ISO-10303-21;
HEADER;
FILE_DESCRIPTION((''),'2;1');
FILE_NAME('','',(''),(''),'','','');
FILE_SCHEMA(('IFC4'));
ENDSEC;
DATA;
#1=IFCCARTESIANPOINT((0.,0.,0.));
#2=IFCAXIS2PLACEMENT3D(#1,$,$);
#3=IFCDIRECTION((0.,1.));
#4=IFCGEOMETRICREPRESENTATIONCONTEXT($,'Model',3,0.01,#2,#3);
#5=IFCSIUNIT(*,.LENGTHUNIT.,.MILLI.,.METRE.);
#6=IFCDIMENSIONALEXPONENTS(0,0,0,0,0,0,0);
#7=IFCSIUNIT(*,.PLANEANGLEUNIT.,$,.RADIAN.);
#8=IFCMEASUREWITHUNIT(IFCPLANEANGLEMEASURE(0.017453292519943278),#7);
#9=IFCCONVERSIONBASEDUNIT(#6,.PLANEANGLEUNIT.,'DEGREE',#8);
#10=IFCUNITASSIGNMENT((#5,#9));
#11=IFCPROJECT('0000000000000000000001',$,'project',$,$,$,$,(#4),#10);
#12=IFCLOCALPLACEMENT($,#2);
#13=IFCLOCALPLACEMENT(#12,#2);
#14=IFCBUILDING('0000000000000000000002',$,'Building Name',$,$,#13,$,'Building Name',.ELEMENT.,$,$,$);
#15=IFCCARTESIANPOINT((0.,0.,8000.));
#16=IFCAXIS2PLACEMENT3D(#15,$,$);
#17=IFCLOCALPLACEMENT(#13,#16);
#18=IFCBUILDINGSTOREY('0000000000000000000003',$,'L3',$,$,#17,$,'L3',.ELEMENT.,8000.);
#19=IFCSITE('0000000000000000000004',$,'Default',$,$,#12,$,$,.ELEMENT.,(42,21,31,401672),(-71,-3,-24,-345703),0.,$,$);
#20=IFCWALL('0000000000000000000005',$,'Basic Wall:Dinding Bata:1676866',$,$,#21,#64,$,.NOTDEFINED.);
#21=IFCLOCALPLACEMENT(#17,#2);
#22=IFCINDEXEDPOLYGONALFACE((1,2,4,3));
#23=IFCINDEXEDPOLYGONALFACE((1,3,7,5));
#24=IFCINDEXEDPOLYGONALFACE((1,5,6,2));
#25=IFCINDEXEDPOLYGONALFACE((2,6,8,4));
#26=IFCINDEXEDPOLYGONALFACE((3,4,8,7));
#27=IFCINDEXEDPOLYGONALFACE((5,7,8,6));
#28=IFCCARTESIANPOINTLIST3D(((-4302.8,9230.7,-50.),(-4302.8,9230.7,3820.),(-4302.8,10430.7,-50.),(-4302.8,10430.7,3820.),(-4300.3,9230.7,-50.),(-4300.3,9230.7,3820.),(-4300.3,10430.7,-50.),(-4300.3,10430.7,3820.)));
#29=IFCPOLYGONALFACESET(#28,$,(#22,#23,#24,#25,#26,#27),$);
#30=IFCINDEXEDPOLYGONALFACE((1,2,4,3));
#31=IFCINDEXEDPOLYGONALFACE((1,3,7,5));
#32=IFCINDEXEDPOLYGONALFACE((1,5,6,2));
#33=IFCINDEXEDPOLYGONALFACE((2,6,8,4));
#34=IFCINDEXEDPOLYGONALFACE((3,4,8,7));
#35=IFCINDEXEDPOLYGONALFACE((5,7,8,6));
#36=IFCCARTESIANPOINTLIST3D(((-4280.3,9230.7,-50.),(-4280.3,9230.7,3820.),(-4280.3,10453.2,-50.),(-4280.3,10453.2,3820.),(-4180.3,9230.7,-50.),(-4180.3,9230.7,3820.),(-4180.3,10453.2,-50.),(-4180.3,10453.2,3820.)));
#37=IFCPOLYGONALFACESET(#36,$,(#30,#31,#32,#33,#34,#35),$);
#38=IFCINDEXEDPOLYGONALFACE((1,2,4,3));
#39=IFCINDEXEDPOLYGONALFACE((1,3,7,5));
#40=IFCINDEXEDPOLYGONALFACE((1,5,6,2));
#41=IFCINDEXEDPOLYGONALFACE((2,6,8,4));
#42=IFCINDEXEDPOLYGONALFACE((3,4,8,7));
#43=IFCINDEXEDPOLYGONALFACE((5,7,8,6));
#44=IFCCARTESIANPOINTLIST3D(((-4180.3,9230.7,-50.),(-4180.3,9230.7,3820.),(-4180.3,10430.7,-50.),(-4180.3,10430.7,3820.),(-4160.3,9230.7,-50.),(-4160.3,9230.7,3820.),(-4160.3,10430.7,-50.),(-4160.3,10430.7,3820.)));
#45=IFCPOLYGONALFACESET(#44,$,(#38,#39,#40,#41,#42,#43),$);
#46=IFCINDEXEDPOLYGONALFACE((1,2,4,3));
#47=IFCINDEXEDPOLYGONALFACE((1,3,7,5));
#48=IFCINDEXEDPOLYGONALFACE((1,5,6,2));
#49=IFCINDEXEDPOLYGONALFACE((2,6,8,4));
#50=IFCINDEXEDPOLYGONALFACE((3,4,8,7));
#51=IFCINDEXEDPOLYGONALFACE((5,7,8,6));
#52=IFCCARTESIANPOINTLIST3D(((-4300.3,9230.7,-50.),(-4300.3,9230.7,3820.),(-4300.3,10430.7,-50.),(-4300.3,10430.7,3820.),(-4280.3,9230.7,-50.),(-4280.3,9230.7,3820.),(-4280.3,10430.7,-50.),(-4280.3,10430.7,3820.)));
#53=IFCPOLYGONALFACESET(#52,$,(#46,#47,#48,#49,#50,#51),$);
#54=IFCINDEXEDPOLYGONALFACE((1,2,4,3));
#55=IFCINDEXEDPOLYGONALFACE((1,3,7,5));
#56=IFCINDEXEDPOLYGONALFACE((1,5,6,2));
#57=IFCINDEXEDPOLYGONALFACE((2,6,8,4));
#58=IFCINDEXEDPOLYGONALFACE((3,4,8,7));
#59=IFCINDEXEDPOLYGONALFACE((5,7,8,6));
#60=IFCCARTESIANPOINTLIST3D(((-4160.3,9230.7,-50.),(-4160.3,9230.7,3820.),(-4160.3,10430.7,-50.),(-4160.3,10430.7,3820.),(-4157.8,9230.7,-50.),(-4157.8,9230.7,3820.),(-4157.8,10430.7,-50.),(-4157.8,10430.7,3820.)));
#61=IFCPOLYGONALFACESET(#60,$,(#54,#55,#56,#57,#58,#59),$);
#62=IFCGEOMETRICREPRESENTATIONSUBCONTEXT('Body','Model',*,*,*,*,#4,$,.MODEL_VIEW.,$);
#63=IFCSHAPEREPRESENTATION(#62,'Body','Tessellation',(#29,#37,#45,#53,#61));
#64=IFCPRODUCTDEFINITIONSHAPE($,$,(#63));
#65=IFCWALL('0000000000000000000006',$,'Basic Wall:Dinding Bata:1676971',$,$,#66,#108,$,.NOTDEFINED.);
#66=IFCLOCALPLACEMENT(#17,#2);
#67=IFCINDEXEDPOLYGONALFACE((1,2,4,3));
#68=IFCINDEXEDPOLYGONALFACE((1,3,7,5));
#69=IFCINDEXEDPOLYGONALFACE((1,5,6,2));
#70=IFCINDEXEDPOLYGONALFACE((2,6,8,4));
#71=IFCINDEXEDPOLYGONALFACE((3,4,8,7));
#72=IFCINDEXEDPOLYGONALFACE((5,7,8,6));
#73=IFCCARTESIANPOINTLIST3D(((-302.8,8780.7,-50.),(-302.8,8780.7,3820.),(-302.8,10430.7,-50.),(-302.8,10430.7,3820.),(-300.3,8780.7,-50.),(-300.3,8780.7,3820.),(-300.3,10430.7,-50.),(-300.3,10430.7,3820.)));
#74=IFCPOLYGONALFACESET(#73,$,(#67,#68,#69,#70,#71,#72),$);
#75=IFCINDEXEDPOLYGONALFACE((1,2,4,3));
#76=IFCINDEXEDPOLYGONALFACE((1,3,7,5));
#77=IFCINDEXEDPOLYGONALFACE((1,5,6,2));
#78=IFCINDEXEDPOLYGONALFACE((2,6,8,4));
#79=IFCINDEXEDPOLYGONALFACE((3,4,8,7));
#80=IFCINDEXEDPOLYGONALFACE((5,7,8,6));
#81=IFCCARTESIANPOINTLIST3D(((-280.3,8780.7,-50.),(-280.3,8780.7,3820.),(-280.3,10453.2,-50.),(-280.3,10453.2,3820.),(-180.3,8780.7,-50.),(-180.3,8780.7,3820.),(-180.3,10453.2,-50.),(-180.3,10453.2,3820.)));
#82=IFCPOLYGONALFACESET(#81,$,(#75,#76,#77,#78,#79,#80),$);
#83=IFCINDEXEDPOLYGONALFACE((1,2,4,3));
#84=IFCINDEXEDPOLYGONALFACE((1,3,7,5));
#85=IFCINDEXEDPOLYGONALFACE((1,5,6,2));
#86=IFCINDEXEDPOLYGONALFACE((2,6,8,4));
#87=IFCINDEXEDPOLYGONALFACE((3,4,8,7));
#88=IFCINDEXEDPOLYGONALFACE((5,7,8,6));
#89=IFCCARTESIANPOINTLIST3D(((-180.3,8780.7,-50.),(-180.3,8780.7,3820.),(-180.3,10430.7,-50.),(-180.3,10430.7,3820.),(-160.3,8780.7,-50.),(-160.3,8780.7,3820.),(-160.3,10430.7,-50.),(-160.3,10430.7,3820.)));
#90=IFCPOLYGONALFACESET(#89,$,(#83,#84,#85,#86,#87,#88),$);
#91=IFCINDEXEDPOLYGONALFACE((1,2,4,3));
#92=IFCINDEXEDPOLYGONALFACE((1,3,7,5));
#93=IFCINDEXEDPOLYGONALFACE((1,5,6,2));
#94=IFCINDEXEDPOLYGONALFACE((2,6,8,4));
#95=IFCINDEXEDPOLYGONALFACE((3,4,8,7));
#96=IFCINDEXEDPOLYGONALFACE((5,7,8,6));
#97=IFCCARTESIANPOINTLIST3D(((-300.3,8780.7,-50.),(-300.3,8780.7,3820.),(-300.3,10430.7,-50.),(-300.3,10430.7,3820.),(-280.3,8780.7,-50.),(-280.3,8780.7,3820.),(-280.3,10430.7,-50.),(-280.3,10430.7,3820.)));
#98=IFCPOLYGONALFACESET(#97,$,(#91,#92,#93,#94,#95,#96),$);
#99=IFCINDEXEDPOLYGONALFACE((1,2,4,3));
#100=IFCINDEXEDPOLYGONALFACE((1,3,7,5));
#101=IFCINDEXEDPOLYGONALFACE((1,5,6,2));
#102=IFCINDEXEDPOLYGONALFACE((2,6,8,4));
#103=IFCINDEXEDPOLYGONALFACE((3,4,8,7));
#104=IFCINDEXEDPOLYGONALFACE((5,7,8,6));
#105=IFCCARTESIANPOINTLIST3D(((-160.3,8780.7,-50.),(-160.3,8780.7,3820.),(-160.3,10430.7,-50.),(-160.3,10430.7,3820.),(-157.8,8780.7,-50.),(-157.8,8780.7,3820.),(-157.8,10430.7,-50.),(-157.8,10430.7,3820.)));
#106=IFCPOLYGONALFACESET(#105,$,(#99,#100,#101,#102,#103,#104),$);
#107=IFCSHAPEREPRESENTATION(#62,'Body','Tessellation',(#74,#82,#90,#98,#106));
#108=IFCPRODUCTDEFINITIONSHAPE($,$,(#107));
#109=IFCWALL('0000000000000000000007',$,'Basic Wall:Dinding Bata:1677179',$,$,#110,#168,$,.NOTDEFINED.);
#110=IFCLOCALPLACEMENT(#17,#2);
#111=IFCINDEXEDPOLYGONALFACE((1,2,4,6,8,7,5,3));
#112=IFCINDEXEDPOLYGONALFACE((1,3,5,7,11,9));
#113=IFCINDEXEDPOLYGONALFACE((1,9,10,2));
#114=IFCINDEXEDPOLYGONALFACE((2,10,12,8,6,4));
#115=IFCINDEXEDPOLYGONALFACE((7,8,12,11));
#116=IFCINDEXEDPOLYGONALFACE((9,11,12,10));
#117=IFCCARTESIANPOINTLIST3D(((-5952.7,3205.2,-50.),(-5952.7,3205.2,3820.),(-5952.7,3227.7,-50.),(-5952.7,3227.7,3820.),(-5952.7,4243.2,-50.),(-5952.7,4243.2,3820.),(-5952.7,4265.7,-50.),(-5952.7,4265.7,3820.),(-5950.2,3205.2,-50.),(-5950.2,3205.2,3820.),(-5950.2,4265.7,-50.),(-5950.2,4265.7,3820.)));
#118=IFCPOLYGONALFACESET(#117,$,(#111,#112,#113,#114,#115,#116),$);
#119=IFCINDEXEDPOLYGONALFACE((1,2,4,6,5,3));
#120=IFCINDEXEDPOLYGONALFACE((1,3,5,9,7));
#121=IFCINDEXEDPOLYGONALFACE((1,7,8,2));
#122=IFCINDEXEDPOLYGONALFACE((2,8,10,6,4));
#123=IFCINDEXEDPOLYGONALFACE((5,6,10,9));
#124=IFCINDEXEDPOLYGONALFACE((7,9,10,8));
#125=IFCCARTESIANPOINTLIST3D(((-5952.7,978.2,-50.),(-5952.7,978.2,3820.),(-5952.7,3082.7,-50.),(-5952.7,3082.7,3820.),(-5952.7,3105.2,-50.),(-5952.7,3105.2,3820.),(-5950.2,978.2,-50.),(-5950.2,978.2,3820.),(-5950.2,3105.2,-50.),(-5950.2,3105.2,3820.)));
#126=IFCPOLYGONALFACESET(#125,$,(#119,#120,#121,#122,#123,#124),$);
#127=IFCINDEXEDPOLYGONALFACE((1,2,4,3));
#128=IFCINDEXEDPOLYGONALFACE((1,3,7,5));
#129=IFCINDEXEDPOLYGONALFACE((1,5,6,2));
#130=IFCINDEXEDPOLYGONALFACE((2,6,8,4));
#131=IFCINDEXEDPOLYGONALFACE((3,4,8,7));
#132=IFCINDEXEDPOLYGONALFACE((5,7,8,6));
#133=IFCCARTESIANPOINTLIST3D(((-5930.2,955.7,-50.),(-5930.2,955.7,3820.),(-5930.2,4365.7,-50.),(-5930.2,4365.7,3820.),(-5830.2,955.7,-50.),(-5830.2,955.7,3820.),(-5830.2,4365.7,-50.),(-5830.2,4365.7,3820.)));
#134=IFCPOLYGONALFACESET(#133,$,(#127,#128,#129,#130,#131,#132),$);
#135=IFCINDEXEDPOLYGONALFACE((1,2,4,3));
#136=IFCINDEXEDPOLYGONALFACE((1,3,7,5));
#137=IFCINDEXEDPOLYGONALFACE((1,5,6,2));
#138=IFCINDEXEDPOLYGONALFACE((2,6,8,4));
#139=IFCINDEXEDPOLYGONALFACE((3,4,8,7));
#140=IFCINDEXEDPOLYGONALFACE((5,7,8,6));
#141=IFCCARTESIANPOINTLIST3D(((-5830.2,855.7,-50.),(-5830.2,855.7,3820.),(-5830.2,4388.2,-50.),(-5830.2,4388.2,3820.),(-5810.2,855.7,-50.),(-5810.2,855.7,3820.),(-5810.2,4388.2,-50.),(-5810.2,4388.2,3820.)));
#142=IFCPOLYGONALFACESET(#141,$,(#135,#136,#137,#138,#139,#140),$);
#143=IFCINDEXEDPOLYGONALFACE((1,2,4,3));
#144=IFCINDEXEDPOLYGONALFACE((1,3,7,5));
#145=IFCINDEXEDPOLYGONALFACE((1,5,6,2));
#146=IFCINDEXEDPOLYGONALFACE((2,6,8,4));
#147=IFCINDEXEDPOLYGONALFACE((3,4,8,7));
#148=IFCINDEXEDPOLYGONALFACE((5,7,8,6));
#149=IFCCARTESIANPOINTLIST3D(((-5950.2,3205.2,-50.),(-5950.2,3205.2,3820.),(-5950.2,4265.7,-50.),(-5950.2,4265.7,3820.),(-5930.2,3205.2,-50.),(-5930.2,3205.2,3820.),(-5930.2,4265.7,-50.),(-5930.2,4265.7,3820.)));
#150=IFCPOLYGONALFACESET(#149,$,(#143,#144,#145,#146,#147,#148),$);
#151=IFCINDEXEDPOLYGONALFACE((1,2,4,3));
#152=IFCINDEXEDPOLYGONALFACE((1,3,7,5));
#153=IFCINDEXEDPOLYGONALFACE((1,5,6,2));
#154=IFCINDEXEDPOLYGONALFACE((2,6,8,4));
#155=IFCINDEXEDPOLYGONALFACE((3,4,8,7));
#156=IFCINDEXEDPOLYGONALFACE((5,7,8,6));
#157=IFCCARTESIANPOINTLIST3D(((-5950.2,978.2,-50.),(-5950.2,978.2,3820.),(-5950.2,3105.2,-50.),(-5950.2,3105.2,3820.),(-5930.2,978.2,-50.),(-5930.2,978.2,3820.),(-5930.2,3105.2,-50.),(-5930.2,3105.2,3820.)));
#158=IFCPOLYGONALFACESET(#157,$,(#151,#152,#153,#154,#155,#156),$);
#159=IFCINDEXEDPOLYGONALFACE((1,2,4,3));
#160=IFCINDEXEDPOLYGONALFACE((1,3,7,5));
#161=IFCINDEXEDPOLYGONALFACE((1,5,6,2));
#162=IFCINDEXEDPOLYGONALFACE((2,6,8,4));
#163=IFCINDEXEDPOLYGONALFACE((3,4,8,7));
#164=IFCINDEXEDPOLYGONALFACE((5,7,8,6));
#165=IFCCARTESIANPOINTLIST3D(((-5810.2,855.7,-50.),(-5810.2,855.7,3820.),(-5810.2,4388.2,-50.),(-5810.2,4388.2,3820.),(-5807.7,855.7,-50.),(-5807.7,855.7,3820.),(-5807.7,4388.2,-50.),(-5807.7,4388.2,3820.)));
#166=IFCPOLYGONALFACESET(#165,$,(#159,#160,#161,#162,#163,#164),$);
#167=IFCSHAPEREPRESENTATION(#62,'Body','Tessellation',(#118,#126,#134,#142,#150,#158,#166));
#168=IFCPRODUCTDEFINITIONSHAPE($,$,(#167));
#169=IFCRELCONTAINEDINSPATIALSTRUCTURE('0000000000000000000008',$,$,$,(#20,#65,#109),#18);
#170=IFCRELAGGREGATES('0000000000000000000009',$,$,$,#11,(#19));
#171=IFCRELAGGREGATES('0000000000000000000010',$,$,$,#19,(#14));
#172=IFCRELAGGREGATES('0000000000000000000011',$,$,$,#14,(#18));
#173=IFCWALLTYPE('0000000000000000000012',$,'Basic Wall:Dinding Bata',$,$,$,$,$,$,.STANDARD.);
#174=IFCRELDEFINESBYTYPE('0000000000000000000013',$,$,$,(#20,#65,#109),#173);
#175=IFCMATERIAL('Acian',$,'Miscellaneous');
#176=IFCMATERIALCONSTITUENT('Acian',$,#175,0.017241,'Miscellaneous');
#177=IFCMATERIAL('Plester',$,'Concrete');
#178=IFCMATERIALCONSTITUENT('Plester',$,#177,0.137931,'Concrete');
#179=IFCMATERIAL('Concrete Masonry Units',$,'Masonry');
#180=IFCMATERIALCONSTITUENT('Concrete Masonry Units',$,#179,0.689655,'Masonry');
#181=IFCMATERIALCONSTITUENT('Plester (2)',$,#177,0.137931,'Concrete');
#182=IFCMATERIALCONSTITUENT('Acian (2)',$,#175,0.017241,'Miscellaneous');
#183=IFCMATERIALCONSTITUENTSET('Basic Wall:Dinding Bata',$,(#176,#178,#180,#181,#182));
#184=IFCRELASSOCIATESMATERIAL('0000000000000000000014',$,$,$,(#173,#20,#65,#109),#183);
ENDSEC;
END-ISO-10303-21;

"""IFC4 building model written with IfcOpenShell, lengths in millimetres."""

from ifc_helpers import new_model, entity, si_unit, converted_unit, direction, frame, origin, place, context, subcontext, project, spatial, indexed_curve, outline, extrude, material, constituent, constituent_set, type_object, element, save


model = new_model("IFC4")

# Units and contexts
model_context = context("Model", 3, precision=0.01, world=origin(), true_north=direction((0.0, 1.0)))
body_context = subcontext(model_context, "Body", "Model", "MODEL_VIEW")
ifc_project = project(units=[si_unit("LENGTHUNIT", "METRE", prefix="MILLI"), converted_unit("PLANEANGLEUNIT", "DEGREE", entity("IfcPlaneAngleMeasure", 0.017453292519943278), si_unit("PLANEANGLEUNIT", "RADIAN"), dimensions=[0, 0, 0, 0, 0, 0, 0])], contexts=[model_context])

# Site, building, storey
site_placement = place(None, origin())
site = spatial("IfcSite", under=ifc_project, at=site_placement, Name="Default", CompositionType="ELEMENT", RefLatitude=(42, 21, 31, 401672), RefLongitude=(-71, -3, -24, -345703), RefElevation=0.0)
building_placement = place(site_placement, origin())
building = spatial("IfcBuilding", under=site, at=building_placement, Name="Building Name", LongName="Building Name", CompositionType="ELEMENT")
storey_placement = place(building_placement, frame((0.0, 0.0, 8000.0)))
storey = spatial("IfcBuildingStorey", under=building, at=storey_placement, Name="L3", LongName="L3", CompositionType="ELEMENT", Elevation=8000.0)

# Walls
ifc_material_1 = material(Name="Acian", Category="Miscellaneous")
ifc_constituent_1 = constituent(ifc_material_1, Name="Acian", Category="Miscellaneous", fraction=0.017241)
ifc_material_2 = material(Name="Plester", Category="Concrete")
ifc_constituent_2 = constituent(ifc_material_2, Name="Plester", Category="Concrete", fraction=0.137931)
ifc_material_3 = material(Name="Concrete Masonry Units", Category="Masonry")
ifc_constituent_3 = constituent(ifc_material_3, Name="Concrete Masonry Units", Category="Masonry", fraction=0.689655)
ifc_constituent_4 = constituent(ifc_material_2, Name="Plester (2)", Category="Concrete", fraction=0.137931)
ifc_constituent_5 = constituent(ifc_material_1, Name="Acian (2)", Category="Miscellaneous", fraction=0.017241)
ifc_constituent_set = constituent_set(constituents=[ifc_constituent_1, ifc_constituent_2, ifc_constituent_3, ifc_constituent_4, ifc_constituent_5], Name="Basic Wall:Dinding Bata")
wall_type = type_object("IfcWallType", Name="Basic Wall:Dinding Bata", PredefinedType="STANDARD", material=ifc_constituent_set)
wall_1_placement = place(storey_placement, frame((-4230.3, 9230.7, -50.0), z_axis=(0.0, 0.0, 1.0), x_axis=(0.0, 1.0, 0.0)))
element("IfcWall", 1, at=wall_1_placement, inside=storey, type_object=wall_type, material=ifc_constituent_set, Name="Basic Wall:Dinding Bata:1676866", PredefinedType="NOTDEFINED", context=body_context, shape_type="SweptSolid", body=[
    extrude(outline(indexed_curve([(-1.3, -600.0), (1.2, -600.0), (1.3, 600.0), (-1.2, 600.0), (-1.3, -600.0)], self_intersect=False)), frame((600.0, 71.3, 0.0), z_axis=(0.0, 0.0, 1.0), x_axis=(0.0, -1.0, 0.0)), (0.0, 0.0, 1.0), 3870.0),
    extrude(outline(indexed_curve([(-611.3, -50.0), (611.3, -50.0), (611.3, 50.0), (-611.3, 50.0), (-611.3, -50.0)], self_intersect=False)), frame((611.3, 0.0, 0.0)), (0.0, 0.0, 1.0), 3870.0),
    extrude(outline(indexed_curve([(-600.0, -10.0), (600.0, -10.0), (600.0, 10.0), (-600.0, 10.0), (-600.0, -10.0)], self_intersect=False)), frame((600.0, -60.0, 0.0)), (0.0, 0.0, 1.0), 3870.0),
    extrude(outline(indexed_curve([(-600.0, -10.0), (600.0, -10.0), (600.0, 10.0), (-600.0, 10.0), (-600.0, -10.0)], self_intersect=False)), frame((600.0, 60.0, 0.0)), (0.0, 0.0, 1.0), 3870.0),
    extrude(outline(indexed_curve([(-1.3, -600.0), (1.2, -600.0), (1.3, 600.0), (-1.2, 600.0), (-1.3, -600.0)], self_intersect=False)), frame((600.0, -71.2, 0.0), z_axis=(0.0, 0.0, 1.0), x_axis=(0.0, 1.0, 0.0)), (0.0, 0.0, 1.0), 3870.0),
])
wall_2_placement = place(storey_placement, frame((-230.3, 8780.7, -50.0), z_axis=(0.0, 0.0, 1.0), x_axis=(0.0, 1.0, 0.0)))
element("IfcWall", 2, at=wall_2_placement, inside=storey, type_object=wall_type, material=ifc_constituent_set, Name="Basic Wall:Dinding Bata:1676971", PredefinedType="NOTDEFINED", context=body_context, shape_type="SweptSolid", body=[
    extrude(outline(indexed_curve([(-1.3, -825.0), (1.2, -825.0), (1.3, 825.0), (-1.2, 825.0), (-1.3, -825.0)], self_intersect=False)), frame((825.0, 71.2, 0.0), z_axis=(0.0, 0.0, 1.0), x_axis=(0.0, -1.0, 0.0)), (0.0, 0.0, 1.0), 3870.0),
    extrude(outline(indexed_curve([(-836.3, -50.0), (836.3, -50.0), (836.3, 50.0), (-836.3, 50.0), (-836.3, -50.0)], self_intersect=False)), frame((836.3, 0.0, 0.0)), (0.0, 0.0, 1.0), 3870.0),
    extrude(outline(indexed_curve([(-825.0, -10.0), (825.0, -10.0), (825.0, 10.0), (-825.0, 10.0), (-825.0, -10.0)], self_intersect=False)), frame((825.0, -60.0, 0.0)), (0.0, 0.0, 1.0), 3870.0),
    extrude(outline(indexed_curve([(-825.0, -10.0), (825.0, -10.0), (825.0, 10.0), (-825.0, 10.0), (-825.0, -10.0)], self_intersect=False)), frame((825.0, 60.0, 0.0)), (0.0, 0.0, 1.0), 3870.0),
    extrude(outline(indexed_curve([(-1.3, -825.0), (1.2, -825.0), (1.3, 825.0), (-1.2, 825.0), (-1.3, -825.0)], self_intersect=False)), frame((825.0, -71.3, 0.0), z_axis=(0.0, 0.0, 1.0), x_axis=(0.0, 1.0, 0.0)), (0.0, 0.0, 1.0), 3870.0),
])
wall_3_placement = place(storey_placement, frame((-5880.2, 978.2, -50.0), z_axis=(0.0, 0.0, 1.0), x_axis=(0.0, 1.0, 0.0)))
element("IfcWall", 3, at=wall_3_placement, inside=storey, type_object=wall_type, material=ifc_constituent_set, Name="Basic Wall:Dinding Bata:1677179", PredefinedType="NOTDEFINED", context=body_context, shape_type="SweptSolid", body=[
    extrude(outline(indexed_curve([(-507.7, -0.8), (507.7, -0.8), (530.2, -0.8), (530.2, 1.7), (-530.2, 1.7), (-530.2, -0.8), (-507.7, -0.8)], self_intersect=False)), frame((2757.3, 71.7, 0.0), z_axis=(0.0, 0.0, 1.0), x_axis=(-1.0, 0.0, 0.0)), (0.0, 0.0, 1.0), 3870.0),
    extrude(outline(indexed_curve([(-1271.7, -1.5), (855.3, -1.5), (855.3, 1.0), (832.8, 1.0), (-1271.7, 1.0), (-1271.7, -1.5)], self_intersect=False)), frame((1271.7, 71.5, 0.0)), (0.0, 0.0, 1.0), 3870.0),
    extrude(outline(indexed_curve([(-1705.0, -50.0), (1705.0, -50.0), (1705.0, 50.0), (-1705.0, 50.0), (-1705.0, -50.0)], self_intersect=False)), frame((1682.5, 0.0, 0.0)), (0.0, 0.0, 1.0), 3870.0),
    extrude(outline(indexed_curve([(-1766.2, -10.0), (1766.2, -10.0), (1766.2, 10.0), (-1766.2, 10.0), (-1766.2, -10.0)], self_intersect=False)), frame((1643.7, -60.0, 0.0)), (0.0, 0.0, 1.0), 3870.0),
    extrude(outline(indexed_curve([(-530.2, -10.0), (530.2, -10.0), (530.2, 10.0), (-530.2, 10.0), (-530.2, -10.0)], self_intersect=False)), frame((2757.3, 60.0, 0.0), z_axis=(0.0, 0.0, 1.0), x_axis=(-1.0, 0.0, 0.0)), (0.0, 0.0, 1.0), 3870.0),
    extrude(outline(indexed_curve([(-1063.5, -10.0), (1063.5, -10.0), (1063.5, 10.0), (-1063.5, 10.0), (-1063.5, -10.0)], self_intersect=False)), frame((1063.5, 60.0, 0.0)), (0.0, 0.0, 1.0), 3870.0),
    extrude(outline(indexed_curve([(-1.3, -1766.2), (1.2, -1766.2), (1.3, 1766.2), (-1.2, 1766.2), (-1.3, -1766.2)], self_intersect=False)), frame((1643.7, -71.3, 0.0), z_axis=(0.0, 0.0, 1.0), x_axis=(0.0, 1.0, 0.0)), (0.0, 0.0, 1.0), 3870.0),
])

save(model, "model.ifc")
